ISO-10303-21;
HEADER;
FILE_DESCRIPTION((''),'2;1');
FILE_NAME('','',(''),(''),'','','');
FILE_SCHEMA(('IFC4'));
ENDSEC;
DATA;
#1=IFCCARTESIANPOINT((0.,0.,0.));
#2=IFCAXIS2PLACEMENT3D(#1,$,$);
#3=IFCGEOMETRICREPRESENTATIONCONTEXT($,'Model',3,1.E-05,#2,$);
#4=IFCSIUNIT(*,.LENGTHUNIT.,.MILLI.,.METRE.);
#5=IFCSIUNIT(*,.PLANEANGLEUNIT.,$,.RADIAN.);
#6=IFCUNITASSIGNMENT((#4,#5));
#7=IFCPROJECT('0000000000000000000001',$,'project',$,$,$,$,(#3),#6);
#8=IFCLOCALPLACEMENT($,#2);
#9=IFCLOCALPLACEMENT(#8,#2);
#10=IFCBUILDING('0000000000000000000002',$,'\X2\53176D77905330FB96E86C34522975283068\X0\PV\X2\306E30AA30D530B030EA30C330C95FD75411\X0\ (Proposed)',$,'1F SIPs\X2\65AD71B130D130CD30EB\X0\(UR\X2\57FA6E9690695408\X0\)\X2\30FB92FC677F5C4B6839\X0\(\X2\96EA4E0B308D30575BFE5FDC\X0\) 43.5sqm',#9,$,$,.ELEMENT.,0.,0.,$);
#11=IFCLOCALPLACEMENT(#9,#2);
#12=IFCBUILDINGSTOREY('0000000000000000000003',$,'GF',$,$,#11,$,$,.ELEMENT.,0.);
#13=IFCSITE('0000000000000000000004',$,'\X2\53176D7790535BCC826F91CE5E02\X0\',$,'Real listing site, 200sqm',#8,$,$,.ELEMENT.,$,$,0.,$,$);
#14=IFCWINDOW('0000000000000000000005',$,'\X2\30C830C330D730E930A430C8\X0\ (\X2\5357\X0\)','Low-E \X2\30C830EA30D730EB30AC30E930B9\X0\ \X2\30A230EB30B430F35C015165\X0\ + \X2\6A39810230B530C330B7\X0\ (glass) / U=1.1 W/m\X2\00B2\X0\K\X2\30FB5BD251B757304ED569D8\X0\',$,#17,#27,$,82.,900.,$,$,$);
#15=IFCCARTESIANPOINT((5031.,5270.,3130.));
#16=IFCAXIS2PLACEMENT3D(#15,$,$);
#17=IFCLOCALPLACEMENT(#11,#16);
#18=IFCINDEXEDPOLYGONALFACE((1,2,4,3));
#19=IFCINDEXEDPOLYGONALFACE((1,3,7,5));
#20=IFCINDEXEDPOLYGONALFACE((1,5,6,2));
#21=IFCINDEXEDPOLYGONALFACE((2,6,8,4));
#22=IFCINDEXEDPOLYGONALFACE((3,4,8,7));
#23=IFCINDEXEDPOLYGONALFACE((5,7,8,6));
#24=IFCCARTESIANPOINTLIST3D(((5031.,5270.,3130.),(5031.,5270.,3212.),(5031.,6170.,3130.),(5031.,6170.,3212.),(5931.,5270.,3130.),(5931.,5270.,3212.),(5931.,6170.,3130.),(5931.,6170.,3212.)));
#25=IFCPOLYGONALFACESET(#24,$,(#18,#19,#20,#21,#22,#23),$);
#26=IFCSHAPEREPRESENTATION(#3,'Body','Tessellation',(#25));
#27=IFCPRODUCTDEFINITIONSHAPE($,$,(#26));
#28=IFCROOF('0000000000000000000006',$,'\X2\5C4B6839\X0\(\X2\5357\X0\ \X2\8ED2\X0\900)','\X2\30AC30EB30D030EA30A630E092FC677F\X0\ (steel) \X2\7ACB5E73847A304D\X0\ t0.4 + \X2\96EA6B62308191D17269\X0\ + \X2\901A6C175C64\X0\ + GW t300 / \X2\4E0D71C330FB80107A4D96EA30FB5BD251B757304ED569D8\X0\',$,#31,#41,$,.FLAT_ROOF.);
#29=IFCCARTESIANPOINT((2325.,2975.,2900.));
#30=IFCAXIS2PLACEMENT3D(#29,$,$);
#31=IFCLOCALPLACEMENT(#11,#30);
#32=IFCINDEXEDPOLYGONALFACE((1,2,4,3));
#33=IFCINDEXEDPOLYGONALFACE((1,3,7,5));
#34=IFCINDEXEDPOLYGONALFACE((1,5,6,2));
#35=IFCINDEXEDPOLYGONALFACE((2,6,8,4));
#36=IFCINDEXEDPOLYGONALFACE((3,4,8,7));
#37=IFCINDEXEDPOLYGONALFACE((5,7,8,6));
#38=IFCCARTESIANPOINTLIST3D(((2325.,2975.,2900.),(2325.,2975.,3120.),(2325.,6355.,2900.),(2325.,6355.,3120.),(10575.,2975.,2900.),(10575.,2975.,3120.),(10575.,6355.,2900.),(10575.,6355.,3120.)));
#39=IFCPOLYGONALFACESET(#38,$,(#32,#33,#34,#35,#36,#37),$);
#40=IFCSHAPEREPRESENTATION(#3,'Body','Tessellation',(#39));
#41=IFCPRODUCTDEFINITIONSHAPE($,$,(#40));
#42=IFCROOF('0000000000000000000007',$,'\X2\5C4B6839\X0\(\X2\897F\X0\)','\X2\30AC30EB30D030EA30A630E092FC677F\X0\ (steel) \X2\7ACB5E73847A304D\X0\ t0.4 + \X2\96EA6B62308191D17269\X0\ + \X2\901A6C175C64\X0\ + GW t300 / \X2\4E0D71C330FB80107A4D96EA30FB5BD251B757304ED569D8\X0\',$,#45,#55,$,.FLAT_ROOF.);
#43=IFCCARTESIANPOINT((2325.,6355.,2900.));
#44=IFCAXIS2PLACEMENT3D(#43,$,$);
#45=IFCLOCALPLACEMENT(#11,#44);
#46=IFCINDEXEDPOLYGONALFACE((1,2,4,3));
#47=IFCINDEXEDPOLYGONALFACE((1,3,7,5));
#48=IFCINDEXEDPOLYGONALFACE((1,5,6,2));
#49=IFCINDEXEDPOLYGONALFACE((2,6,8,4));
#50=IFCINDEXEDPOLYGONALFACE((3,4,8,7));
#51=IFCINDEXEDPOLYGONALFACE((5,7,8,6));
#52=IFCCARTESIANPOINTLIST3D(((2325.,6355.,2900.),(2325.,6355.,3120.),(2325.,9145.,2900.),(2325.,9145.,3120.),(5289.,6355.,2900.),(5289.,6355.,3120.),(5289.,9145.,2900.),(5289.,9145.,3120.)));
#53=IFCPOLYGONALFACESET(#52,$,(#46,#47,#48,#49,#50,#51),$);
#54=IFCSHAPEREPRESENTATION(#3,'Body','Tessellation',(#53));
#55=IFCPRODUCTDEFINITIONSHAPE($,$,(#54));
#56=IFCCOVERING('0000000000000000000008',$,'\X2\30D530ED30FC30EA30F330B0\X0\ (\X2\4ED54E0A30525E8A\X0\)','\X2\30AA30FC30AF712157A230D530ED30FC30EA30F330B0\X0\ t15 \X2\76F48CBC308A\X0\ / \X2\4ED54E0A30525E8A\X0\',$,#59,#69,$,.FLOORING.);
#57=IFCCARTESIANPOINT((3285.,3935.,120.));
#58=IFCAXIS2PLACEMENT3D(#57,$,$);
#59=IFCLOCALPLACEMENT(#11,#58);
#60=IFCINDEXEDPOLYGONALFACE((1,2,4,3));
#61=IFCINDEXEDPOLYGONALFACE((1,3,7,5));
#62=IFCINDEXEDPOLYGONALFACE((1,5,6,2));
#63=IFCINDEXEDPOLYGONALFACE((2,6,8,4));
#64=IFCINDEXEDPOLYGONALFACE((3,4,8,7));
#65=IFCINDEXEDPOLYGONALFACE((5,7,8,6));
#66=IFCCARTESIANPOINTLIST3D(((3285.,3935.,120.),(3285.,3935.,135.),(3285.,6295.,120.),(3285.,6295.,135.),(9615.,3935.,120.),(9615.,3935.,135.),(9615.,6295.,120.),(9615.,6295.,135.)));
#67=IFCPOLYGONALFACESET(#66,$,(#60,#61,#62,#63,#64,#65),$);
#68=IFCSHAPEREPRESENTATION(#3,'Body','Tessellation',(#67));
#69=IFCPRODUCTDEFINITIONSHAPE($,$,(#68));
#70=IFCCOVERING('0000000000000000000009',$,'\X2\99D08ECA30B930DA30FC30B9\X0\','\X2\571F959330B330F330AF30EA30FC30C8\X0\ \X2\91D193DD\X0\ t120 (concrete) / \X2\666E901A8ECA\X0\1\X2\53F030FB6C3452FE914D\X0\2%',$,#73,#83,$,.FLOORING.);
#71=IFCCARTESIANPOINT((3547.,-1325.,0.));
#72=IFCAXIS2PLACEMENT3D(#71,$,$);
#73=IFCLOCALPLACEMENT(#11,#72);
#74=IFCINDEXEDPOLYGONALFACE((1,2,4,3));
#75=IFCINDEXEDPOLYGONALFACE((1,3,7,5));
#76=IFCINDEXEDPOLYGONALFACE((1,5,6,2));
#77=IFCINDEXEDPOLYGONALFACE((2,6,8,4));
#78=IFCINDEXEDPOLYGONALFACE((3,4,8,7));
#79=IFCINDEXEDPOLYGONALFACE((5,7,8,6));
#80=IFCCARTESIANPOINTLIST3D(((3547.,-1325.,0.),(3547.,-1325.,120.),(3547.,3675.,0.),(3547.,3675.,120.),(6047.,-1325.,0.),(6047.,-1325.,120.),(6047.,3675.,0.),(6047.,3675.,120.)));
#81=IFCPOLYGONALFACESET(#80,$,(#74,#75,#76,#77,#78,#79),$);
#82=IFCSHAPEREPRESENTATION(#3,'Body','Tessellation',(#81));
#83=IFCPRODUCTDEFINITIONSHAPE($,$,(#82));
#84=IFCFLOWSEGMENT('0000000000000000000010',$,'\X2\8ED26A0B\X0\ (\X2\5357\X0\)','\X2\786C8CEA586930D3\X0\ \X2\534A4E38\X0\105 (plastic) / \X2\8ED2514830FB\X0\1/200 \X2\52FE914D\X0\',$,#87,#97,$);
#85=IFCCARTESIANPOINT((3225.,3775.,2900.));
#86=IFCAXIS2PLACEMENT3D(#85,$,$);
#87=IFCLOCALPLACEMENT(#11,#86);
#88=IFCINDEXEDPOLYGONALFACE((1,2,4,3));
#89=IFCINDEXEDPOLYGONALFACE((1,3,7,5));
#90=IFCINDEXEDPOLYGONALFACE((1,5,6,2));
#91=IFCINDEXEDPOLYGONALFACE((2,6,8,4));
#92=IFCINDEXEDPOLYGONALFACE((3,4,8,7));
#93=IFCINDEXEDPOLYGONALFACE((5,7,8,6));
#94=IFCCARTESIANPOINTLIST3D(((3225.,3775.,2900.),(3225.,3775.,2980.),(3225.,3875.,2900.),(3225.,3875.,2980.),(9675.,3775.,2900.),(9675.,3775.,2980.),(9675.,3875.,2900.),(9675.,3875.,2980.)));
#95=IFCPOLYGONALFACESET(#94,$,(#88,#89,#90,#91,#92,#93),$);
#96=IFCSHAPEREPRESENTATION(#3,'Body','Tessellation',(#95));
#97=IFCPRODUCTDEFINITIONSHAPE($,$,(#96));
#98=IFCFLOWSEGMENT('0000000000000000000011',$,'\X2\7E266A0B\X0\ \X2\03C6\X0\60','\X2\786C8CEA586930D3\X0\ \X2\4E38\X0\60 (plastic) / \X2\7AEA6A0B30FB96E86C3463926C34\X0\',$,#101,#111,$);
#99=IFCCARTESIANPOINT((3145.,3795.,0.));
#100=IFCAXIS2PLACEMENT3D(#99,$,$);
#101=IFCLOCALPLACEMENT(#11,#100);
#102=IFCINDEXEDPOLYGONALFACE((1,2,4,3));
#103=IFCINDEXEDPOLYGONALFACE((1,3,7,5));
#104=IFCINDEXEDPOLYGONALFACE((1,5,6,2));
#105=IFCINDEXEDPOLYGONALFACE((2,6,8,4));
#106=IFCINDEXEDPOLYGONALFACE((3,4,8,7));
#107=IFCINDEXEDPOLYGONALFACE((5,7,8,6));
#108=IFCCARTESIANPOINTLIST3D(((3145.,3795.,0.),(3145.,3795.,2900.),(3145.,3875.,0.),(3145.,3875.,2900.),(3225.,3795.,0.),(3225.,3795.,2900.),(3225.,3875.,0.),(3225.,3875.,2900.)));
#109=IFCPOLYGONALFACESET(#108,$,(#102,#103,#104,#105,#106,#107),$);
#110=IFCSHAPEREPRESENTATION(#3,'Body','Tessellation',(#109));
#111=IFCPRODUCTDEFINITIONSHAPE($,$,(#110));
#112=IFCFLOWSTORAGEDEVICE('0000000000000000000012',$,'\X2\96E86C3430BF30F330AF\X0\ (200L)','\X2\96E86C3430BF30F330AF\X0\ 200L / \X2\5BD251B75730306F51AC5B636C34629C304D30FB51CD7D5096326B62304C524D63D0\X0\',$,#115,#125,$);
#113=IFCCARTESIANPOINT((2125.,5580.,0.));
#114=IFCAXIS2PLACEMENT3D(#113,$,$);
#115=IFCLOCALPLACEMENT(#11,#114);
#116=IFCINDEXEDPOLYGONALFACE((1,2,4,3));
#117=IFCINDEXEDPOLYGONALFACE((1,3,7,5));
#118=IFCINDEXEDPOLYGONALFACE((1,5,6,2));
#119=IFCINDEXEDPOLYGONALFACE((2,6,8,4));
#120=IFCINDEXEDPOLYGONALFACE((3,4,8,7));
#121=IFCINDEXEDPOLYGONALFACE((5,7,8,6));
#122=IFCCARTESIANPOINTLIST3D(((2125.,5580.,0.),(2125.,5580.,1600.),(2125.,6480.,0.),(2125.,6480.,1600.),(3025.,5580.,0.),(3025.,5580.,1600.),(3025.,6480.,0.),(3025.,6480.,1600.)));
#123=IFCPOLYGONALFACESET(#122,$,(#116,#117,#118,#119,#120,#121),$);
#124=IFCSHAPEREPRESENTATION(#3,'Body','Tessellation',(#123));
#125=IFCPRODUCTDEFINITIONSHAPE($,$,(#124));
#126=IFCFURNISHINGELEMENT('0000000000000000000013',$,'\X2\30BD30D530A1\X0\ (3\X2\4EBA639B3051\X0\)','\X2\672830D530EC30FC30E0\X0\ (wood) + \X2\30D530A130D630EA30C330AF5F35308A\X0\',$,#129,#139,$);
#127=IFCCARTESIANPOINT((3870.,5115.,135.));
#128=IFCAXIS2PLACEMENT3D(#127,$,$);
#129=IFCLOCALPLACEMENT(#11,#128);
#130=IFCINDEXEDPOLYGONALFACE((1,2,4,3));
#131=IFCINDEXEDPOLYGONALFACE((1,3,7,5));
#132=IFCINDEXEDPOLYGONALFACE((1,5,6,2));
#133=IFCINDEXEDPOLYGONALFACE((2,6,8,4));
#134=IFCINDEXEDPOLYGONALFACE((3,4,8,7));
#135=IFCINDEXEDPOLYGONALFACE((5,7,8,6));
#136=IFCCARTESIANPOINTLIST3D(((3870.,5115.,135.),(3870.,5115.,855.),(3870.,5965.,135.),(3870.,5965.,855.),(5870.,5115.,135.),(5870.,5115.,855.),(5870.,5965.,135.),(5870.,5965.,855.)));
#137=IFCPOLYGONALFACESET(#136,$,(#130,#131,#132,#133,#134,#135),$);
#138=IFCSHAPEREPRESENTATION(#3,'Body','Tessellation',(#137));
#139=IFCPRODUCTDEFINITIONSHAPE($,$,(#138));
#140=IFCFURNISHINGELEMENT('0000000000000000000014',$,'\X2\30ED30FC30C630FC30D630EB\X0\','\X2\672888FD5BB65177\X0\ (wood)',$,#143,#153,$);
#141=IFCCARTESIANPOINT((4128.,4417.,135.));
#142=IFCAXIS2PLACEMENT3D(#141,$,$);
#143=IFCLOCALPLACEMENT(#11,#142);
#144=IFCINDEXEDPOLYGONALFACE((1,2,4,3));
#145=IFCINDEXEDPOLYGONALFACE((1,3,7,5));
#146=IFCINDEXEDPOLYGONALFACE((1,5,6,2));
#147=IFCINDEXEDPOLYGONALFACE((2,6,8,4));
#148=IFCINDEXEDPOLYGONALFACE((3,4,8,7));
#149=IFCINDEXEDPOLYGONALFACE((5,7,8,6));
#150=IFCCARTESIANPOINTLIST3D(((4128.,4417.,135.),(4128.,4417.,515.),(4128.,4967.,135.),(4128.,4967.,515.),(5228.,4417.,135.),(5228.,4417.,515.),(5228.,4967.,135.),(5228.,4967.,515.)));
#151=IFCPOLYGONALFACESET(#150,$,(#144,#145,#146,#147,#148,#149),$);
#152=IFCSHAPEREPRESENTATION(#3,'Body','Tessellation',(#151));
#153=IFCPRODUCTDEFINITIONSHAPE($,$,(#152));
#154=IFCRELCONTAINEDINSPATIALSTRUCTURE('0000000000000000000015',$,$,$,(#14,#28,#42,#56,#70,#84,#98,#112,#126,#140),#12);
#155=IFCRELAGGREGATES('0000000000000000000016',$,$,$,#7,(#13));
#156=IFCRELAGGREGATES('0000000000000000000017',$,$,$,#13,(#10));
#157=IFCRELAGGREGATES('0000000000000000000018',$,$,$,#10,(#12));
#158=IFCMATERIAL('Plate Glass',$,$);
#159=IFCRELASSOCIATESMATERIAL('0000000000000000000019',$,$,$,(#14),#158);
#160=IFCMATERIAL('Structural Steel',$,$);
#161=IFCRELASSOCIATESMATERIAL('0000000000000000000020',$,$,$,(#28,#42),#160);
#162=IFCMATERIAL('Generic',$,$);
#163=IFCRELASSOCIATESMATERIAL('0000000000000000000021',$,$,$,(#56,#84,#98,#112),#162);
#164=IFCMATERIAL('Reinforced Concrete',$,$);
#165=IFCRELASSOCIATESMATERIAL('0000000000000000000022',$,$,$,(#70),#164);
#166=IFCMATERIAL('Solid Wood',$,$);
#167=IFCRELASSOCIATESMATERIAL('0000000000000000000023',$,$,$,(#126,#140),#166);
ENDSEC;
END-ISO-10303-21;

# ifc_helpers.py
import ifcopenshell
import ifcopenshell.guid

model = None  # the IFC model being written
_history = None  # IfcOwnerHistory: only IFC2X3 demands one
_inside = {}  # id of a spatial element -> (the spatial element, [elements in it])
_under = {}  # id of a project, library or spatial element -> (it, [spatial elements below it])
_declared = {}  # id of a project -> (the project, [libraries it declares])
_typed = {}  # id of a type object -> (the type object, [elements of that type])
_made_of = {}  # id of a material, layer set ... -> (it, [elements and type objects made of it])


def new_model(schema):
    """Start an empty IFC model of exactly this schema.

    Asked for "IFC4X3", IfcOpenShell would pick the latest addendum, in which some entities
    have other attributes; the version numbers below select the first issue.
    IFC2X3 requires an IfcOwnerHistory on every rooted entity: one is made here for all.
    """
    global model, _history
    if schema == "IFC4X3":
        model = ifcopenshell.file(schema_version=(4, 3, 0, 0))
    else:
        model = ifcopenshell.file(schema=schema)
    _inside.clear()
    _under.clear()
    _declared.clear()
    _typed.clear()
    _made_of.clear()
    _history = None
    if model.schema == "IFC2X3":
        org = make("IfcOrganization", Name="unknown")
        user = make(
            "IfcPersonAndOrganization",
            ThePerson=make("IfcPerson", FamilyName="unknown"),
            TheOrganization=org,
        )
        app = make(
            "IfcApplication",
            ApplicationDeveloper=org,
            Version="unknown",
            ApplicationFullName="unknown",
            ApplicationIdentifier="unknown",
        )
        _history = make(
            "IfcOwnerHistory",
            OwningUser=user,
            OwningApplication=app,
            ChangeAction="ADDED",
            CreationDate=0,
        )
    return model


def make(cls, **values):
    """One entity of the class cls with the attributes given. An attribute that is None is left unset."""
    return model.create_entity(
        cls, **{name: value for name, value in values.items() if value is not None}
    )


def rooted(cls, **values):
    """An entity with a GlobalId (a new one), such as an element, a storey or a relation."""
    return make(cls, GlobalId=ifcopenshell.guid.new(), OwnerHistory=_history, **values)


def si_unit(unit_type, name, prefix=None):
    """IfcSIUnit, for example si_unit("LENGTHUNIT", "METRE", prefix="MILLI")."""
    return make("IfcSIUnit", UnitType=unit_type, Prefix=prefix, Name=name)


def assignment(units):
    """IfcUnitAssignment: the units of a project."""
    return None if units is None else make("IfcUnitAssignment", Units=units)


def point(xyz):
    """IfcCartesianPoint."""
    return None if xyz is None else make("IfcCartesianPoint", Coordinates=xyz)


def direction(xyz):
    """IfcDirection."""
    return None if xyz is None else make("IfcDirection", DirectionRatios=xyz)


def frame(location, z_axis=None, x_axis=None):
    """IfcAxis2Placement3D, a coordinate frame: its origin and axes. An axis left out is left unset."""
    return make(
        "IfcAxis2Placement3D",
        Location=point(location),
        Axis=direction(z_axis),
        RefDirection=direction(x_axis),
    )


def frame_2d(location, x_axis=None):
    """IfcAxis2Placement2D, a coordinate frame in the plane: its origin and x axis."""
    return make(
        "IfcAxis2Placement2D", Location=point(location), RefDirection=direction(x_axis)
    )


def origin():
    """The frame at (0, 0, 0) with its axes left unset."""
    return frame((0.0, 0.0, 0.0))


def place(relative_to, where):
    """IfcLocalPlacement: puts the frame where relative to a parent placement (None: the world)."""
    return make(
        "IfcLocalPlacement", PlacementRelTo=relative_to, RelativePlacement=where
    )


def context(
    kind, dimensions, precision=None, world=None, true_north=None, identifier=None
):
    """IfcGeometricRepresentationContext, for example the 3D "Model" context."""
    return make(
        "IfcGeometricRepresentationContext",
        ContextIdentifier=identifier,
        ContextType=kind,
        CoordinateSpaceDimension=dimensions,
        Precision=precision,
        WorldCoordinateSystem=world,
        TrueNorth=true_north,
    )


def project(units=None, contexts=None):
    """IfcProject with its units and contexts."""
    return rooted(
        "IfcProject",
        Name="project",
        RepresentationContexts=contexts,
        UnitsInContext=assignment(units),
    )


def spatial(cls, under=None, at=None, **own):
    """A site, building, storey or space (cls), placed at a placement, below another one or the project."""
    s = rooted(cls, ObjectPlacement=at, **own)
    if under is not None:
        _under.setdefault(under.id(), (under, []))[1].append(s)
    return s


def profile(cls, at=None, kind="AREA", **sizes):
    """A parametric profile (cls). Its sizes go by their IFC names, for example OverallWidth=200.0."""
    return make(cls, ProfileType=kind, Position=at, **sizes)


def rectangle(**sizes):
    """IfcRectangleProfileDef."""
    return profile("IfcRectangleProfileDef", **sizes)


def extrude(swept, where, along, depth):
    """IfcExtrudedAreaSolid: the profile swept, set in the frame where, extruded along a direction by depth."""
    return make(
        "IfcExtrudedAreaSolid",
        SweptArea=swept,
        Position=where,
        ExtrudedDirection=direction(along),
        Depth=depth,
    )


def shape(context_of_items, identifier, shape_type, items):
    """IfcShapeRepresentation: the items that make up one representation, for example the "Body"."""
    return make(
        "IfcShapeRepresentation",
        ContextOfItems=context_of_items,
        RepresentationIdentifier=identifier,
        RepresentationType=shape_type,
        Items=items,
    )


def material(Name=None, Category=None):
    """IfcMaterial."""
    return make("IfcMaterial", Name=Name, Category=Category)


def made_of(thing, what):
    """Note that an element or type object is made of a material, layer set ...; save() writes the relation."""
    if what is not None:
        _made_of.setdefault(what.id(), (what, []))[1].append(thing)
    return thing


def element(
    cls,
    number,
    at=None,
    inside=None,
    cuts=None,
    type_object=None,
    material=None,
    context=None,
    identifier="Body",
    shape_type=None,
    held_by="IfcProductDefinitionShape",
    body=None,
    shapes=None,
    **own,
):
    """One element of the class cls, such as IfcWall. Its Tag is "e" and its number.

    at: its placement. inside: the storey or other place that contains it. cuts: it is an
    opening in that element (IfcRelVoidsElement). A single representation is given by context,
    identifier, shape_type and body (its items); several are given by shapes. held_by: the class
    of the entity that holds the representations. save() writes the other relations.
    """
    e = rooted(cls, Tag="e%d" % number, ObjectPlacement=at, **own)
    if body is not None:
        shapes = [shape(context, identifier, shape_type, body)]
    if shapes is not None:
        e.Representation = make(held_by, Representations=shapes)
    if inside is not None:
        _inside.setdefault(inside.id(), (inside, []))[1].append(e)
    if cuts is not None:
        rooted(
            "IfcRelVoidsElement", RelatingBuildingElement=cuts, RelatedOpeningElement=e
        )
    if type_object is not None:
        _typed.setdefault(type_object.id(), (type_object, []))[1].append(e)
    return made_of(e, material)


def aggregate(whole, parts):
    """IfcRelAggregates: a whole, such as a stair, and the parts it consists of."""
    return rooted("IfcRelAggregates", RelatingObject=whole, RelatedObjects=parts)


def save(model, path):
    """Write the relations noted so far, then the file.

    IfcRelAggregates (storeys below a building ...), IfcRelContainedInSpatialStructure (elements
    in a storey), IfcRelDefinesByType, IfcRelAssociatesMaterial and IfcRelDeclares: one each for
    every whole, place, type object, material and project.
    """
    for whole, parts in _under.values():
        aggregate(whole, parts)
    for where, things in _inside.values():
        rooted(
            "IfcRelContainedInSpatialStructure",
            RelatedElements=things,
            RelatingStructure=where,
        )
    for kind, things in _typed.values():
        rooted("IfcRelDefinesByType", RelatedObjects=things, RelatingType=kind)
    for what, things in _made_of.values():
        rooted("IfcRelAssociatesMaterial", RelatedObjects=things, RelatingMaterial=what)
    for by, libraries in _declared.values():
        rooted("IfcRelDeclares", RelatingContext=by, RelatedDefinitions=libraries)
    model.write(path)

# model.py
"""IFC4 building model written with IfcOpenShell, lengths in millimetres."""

from ifc_helpers import new_model, si_unit, frame, frame_2d, origin, place, context, project, spatial, rectangle, extrude, material, element, save


model = new_model("IFC4")

# Units and contexts
model_context = context("Model", 3, precision=1e-05, world=origin())
ifc_project = project(units=[si_unit("LENGTHUNIT", "METRE", prefix="MILLI"), si_unit("PLANEANGLEUNIT", "RADIAN")], contexts=[model_context])

# Site, building, storey
site_placement = place(None, origin())
site = spatial("IfcSite", under=ifc_project, at=site_placement, Name="北海道富良野市", ObjectType="Real listing site, 200sqm", CompositionType="ELEMENT", RefElevation=0.0)
building_placement = place(site_placement, origin())
building = spatial("IfcBuilding", under=site, at=building_placement, Name="北海道・雨水利用とPVのオフグリッド志向 (Proposed)", ObjectType="1F SIPs断熱パネル(UR基準適合)・鋼板屋根(雪下ろし対応) 43.5sqm", CompositionType="ELEMENT", ElevationOfRefHeight=0.0, ElevationOfTerrain=0.0)
storey_placement = place(building_placement, origin())
storey = spatial("IfcBuildingStorey", under=building, at=storey_placement, Name="GF", CompositionType="ELEMENT", Elevation=0.0)

# Shared definitions
ifc_material_1 = material(Name="Solid Wood")

# Shared definitions
ifc_material_2 = material(Name="Reinforced Concrete")

# Shared definitions
ifc_material_3 = material(Name="Plate Glass")

# Window
window_1_placement = place(storey_placement, frame((5031.0, 5270.0, 3130.0)))
element("IfcWindow", 1, at=window_1_placement, inside=storey, material=ifc_material_3, Name="トップライト (南)", Description="Low-E トリプルガラス アルゴン封入 + 樹脂サッシ (glass) / U=1.1 W/m²K・寒冷地仕様", OverallHeight=82.0, OverallWidth=900.0, context=model_context, shape_type="SweptSolid", body=[
    extrude(rectangle(XDim=900.0, YDim=900.0, at=frame_2d((450.0, 450.0))), frame((5031.0, 5270.0, 3130.0)), (0.0, 0.0, 1.0), 82.0),
])

# Roofs
ifc_material_4 = material(Name="Structural Steel")
roof_1_placement = place(storey_placement, frame((2325.0, 2975.0, 2900.0)))
element("IfcRoof", 2, at=roof_1_placement, inside=storey, material=ifc_material_4, Name="屋根(南 軒900)", Description="ガルバリウム鋼板 (steel) 立平葺き t0.4 + 雪止め金物 + 通気層 + GW t300 / 不燃・耐積雪・寒冷地仕様", PredefinedType="FLAT_ROOF", context=model_context, shape_type="SweptSolid", body=[
    extrude(rectangle(XDim=8250.0, YDim=3380.0, at=frame_2d((4125.0, 1690.0))), frame((2325.0, 2975.0, 2900.0)), (0.0, 0.0, 1.0), 220.0),
])
roof_2_placement = place(storey_placement, frame((2325.0, 6355.0, 2900.0)))
element("IfcRoof", 3, at=roof_2_placement, inside=storey, material=ifc_material_4, Name="屋根(西)", Description="ガルバリウム鋼板 (steel) 立平葺き t0.4 + 雪止め金物 + 通気層 + GW t300 / 不燃・耐積雪・寒冷地仕様", PredefinedType="FLAT_ROOF", context=model_context, shape_type="SweptSolid", body=[
    extrude(rectangle(XDim=2964.0, YDim=2790.0, at=frame_2d((1482.0, 1395.0))), frame((2325.0, 6355.0, 2900.0)), (0.0, 0.0, 1.0), 220.0),
])

# Coverings
ifc_material_5 = material(Name="Generic")
covering_1_placement = place(storey_placement, frame((3285.0, 3935.0, 120.0)))
element("IfcCovering", 4, at=covering_1_placement, inside=storey, material=ifc_material_5, Name="フローリング (仕上げ床)", Description="オーク無垢フローリング t15 直貼り / 仕上げ床", PredefinedType="FLOORING", context=model_context, shape_type="SweptSolid", body=[
    extrude(rectangle(XDim=6330.0, YDim=2360.0, at=frame_2d((3165.0, 1180.0))), frame((3285.0, 3935.0, 120.0)), (0.0, 0.0, 1.0), 15.0),
])
covering_2_placement = place(storey_placement, frame((3547.0, -1325.0, 0.0)))
element("IfcCovering", 5, at=covering_2_placement, inside=storey, material=ifc_material_2, Name="駐車スペース", Description="土間コンクリート 金鏝 t120 (concrete) / 普通車1台・水勾配2%", PredefinedType="FLOORING", context=model_context, shape_type="SweptSolid", body=[
    extrude(rectangle(XDim=2500.0, YDim=5000.0, at=frame_2d((1250.0, 2500.0))), frame((3547.0, -1325.0, 0.0)), (0.0, 0.0, 1.0), 120.0),
])

# Flow segments
flow_segment_1_placement = place(storey_placement, frame((3225.0, 3775.0, 2900.0)))
element("IfcFlowSegment", 6, at=flow_segment_1_placement, inside=storey, material=ifc_material_5, Name="軒樋 (南)", Description="硬質塩ビ 半丸105 (plastic) / 軒先・1/200 勾配", context=model_context, shape_type="SweptSolid", body=[
    extrude(rectangle(XDim=6450.0, YDim=100.0, at=frame_2d((3225.0, 50.0))), frame((3225.0, 3775.0, 2900.0)), (0.0, 0.0, 1.0), 80.0),
])
flow_segment_2_placement = place(storey_placement, frame((3145.0, 3795.0, 0.0)))
element("IfcFlowSegment", 7, at=flow_segment_2_placement, inside=storey, material=ifc_material_5, Name="縦樋 φ60", Description="硬質塩ビ 丸60 (plastic) / 竪樋・雨水排水", context=model_context, shape_type="SweptSolid", body=[
    extrude(rectangle(XDim=80.0, YDim=80.0, at=frame_2d((40.0, 40.0))), frame((3145.0, 3795.0, 0.0)), (0.0, 0.0, 1.0), 2900.0),
])

# Flow storage device
flow_storage_device_placement = place(storey_placement, frame((2125.0, 5580.0, 0.0)))
element("IfcFlowStorageDevice", 8, at=flow_storage_device_placement, inside=storey, material=ifc_material_5, Name="雨水タンク (200L)", Description="雨水タンク 200L / 寒冷地は冬季水抜き・凍結防止が前提", context=model_context, shape_type="SweptSolid", body=[
    extrude(rectangle(XDim=900.0, YDim=900.0, at=frame_2d((450.0, 450.0))), frame((2125.0, 5580.0, 0.0)), (0.0, 0.0, 1.0), 1600.0),
])

# Furnishing elements
furnishing_1_placement = place(storey_placement, frame((3870.0, 5115.0, 135.0)))
element("IfcFurnishingElement", 9, at=furnishing_1_placement, inside=storey, material=ifc_material_1, Name="ソファ (3人掛け)", Description="木フレーム (wood) + ファブリック張り", context=model_context, shape_type="SweptSolid", body=[
    extrude(rectangle(XDim=2000.0, YDim=850.0, at=frame_2d((1000.0, 425.0))), frame((3870.0, 5115.0, 135.0)), (0.0, 0.0, 1.0), 720.0),
])
furnishing_2_placement = place(storey_placement, frame((4128.0, 4417.0, 135.0)))
element("IfcFurnishingElement", 10, at=furnishing_2_placement, inside=storey, material=ifc_material_1, Name="ローテーブル", Description="木製家具 (wood)", context=model_context, shape_type="SweptSolid", body=[
    extrude(rectangle(XDim=1100.0, YDim=550.0, at=frame_2d((550.0, 275.0))), frame((4128.0, 4417.0, 135.0)), (0.0, 0.0, 1.0), 380.0),
])

save(model, "model.ifc")
